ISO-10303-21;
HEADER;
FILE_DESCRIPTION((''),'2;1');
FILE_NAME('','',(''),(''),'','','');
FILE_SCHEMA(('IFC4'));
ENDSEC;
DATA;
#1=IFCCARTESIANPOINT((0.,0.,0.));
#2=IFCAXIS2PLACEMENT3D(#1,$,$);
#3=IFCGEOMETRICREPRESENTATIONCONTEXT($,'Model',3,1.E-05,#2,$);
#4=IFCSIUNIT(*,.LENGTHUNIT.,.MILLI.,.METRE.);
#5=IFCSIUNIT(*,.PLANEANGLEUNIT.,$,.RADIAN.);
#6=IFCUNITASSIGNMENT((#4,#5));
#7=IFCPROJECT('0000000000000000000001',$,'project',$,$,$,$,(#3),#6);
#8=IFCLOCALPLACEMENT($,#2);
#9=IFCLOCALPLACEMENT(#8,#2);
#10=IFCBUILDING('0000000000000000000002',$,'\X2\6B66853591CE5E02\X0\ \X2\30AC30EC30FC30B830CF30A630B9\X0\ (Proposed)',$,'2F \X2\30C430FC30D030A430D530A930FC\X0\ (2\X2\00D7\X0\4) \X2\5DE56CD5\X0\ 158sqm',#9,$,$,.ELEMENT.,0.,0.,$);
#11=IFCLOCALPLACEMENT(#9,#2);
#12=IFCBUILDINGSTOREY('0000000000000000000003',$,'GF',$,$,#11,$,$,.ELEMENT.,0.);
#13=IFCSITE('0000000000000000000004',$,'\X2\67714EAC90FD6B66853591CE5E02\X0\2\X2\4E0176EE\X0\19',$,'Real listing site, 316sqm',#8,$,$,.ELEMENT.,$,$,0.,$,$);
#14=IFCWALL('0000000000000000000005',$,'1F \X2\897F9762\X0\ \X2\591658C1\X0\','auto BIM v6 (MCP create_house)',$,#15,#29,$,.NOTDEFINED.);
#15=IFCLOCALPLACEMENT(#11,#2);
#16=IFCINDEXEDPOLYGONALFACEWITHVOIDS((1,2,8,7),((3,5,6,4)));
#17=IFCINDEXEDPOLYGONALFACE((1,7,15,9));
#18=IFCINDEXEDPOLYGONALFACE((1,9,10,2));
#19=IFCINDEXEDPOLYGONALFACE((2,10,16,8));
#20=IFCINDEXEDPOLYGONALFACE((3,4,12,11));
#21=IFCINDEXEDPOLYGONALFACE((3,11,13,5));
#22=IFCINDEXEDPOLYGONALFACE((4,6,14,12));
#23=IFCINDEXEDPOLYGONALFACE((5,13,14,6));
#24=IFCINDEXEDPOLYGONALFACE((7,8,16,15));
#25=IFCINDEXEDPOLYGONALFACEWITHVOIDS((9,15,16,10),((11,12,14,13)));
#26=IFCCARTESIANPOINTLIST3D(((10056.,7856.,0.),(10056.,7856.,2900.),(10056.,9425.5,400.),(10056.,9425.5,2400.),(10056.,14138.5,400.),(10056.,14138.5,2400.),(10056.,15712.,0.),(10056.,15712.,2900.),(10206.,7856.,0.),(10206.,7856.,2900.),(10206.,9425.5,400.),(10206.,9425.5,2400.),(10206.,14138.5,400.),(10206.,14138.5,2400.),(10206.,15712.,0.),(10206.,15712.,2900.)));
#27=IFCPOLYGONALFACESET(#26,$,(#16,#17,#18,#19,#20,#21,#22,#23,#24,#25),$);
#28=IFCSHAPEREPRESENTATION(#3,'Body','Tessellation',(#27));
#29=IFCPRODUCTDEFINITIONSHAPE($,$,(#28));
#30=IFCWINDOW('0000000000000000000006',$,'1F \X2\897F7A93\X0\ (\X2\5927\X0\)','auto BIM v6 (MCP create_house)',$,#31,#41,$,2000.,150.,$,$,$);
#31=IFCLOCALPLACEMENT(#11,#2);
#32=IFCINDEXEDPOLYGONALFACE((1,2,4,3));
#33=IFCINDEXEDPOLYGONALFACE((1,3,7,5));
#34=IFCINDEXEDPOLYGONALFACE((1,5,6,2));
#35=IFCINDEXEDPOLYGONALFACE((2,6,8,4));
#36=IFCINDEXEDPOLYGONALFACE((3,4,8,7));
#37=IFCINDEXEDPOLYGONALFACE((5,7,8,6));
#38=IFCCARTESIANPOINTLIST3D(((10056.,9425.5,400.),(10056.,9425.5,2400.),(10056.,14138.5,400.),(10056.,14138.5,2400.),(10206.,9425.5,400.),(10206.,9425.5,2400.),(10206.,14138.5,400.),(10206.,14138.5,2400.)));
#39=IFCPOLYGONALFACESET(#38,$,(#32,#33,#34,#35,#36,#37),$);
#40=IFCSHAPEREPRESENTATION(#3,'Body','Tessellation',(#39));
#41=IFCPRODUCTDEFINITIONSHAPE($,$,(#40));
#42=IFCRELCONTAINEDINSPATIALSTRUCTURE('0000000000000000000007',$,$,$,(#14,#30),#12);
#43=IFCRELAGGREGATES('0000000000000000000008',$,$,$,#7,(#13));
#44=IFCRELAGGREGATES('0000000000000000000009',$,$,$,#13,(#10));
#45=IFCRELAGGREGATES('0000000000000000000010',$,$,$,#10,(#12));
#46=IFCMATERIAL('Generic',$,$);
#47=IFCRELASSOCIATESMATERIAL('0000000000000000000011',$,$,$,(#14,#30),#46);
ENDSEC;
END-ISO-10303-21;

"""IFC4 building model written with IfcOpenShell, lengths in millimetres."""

from ifc_helpers import new_model, si_unit, frame, frame_2d, origin, place, context, project, spatial, rectangle, extrude, material, element, fill, save


model = new_model("IFC4")

# Units and contexts
model_context = context("Model", 3, precision=1e-05, world=origin())
ifc_project = project(units=[si_unit("LENGTHUNIT", "METRE", prefix="MILLI"), si_unit("PLANEANGLEUNIT", "RADIAN")], contexts=[model_context])

# Site, building, storey
site_placement = place(None, origin())
site = spatial("IfcSite", under=ifc_project, at=site_placement, Name="東京都武蔵野市2丁目19", ObjectType="Real listing site, 316sqm", CompositionType="ELEMENT", RefElevation=0.0)
building_placement = place(site_placement, origin())
building = spatial("IfcBuilding", under=site, at=building_placement, Name="武蔵野市 ガレージハウス (Proposed)", ObjectType="2F ツーバイフォー (2×4) 工法 158sqm", CompositionType="ELEMENT", ElevationOfRefHeight=0.0, ElevationOfTerrain=0.0)
storey_placement = place(building_placement, origin())
storey = spatial("IfcBuildingStorey", under=building, at=storey_placement, Name="GF", CompositionType="ELEMENT", Elevation=0.0)

# Shared definitions
ifc_material = material(Name="Generic")

# Wall, opening, window
wall_1_placement = place(storey_placement, frame((5028.0, 3928.0, 0.0)))
wall_1 = element("IfcWall", 1, at=wall_1_placement, inside=storey, material=ifc_material, Name="1F 西面 外壁", Description="auto BIM v6 (MCP create_house)", PredefinedType="NOTDEFINED", context=model_context, shape_type="SweptSolid", body=[
    extrude(rectangle(XDim=150.0, YDim=7856.0, at=frame_2d((75.0, 3928.0))), frame((5028.0, 3928.0, 0.0)), (0.0, 0.0, 1.0), 2900.0),
])
opening_1_placement = place(storey_placement, frame((5028.0, 4713.0, 200.0)))
opening_1 = element("IfcOpeningElement", 2, at=opening_1_placement, cuts=wall_1, PredefinedType="NOTDEFINED", context=model_context, shape_type="SweptSolid", body=[
    extrude(rectangle(XDim=150.0, YDim=4713.0, at=frame_2d((75.0, 2356.0))), frame((5028.0, 4713.0, 200.0)), (0.0, 0.0, 1.0), 2000.0),
])
window_1_placement = place(storey_placement, frame((5028.0, 4713.0, 200.0)))
window_1 = element("IfcWindow", 3, at=window_1_placement, inside=storey, material=ifc_material, Name="1F 西窓 (大)", Description="auto BIM v6 (MCP create_house)", OverallHeight=2000.0, OverallWidth=150.0, context=model_context, shape_type="SweptSolid", body=[
    extrude(rectangle(XDim=150.0, YDim=4713.0, at=frame_2d((75.0, 2356.0))), frame((5028.0, 4713.0, 200.0)), (0.0, 0.0, 1.0), 2000.0),
])
fill(opening_1, window_1)

save(model, "model.ifc")
